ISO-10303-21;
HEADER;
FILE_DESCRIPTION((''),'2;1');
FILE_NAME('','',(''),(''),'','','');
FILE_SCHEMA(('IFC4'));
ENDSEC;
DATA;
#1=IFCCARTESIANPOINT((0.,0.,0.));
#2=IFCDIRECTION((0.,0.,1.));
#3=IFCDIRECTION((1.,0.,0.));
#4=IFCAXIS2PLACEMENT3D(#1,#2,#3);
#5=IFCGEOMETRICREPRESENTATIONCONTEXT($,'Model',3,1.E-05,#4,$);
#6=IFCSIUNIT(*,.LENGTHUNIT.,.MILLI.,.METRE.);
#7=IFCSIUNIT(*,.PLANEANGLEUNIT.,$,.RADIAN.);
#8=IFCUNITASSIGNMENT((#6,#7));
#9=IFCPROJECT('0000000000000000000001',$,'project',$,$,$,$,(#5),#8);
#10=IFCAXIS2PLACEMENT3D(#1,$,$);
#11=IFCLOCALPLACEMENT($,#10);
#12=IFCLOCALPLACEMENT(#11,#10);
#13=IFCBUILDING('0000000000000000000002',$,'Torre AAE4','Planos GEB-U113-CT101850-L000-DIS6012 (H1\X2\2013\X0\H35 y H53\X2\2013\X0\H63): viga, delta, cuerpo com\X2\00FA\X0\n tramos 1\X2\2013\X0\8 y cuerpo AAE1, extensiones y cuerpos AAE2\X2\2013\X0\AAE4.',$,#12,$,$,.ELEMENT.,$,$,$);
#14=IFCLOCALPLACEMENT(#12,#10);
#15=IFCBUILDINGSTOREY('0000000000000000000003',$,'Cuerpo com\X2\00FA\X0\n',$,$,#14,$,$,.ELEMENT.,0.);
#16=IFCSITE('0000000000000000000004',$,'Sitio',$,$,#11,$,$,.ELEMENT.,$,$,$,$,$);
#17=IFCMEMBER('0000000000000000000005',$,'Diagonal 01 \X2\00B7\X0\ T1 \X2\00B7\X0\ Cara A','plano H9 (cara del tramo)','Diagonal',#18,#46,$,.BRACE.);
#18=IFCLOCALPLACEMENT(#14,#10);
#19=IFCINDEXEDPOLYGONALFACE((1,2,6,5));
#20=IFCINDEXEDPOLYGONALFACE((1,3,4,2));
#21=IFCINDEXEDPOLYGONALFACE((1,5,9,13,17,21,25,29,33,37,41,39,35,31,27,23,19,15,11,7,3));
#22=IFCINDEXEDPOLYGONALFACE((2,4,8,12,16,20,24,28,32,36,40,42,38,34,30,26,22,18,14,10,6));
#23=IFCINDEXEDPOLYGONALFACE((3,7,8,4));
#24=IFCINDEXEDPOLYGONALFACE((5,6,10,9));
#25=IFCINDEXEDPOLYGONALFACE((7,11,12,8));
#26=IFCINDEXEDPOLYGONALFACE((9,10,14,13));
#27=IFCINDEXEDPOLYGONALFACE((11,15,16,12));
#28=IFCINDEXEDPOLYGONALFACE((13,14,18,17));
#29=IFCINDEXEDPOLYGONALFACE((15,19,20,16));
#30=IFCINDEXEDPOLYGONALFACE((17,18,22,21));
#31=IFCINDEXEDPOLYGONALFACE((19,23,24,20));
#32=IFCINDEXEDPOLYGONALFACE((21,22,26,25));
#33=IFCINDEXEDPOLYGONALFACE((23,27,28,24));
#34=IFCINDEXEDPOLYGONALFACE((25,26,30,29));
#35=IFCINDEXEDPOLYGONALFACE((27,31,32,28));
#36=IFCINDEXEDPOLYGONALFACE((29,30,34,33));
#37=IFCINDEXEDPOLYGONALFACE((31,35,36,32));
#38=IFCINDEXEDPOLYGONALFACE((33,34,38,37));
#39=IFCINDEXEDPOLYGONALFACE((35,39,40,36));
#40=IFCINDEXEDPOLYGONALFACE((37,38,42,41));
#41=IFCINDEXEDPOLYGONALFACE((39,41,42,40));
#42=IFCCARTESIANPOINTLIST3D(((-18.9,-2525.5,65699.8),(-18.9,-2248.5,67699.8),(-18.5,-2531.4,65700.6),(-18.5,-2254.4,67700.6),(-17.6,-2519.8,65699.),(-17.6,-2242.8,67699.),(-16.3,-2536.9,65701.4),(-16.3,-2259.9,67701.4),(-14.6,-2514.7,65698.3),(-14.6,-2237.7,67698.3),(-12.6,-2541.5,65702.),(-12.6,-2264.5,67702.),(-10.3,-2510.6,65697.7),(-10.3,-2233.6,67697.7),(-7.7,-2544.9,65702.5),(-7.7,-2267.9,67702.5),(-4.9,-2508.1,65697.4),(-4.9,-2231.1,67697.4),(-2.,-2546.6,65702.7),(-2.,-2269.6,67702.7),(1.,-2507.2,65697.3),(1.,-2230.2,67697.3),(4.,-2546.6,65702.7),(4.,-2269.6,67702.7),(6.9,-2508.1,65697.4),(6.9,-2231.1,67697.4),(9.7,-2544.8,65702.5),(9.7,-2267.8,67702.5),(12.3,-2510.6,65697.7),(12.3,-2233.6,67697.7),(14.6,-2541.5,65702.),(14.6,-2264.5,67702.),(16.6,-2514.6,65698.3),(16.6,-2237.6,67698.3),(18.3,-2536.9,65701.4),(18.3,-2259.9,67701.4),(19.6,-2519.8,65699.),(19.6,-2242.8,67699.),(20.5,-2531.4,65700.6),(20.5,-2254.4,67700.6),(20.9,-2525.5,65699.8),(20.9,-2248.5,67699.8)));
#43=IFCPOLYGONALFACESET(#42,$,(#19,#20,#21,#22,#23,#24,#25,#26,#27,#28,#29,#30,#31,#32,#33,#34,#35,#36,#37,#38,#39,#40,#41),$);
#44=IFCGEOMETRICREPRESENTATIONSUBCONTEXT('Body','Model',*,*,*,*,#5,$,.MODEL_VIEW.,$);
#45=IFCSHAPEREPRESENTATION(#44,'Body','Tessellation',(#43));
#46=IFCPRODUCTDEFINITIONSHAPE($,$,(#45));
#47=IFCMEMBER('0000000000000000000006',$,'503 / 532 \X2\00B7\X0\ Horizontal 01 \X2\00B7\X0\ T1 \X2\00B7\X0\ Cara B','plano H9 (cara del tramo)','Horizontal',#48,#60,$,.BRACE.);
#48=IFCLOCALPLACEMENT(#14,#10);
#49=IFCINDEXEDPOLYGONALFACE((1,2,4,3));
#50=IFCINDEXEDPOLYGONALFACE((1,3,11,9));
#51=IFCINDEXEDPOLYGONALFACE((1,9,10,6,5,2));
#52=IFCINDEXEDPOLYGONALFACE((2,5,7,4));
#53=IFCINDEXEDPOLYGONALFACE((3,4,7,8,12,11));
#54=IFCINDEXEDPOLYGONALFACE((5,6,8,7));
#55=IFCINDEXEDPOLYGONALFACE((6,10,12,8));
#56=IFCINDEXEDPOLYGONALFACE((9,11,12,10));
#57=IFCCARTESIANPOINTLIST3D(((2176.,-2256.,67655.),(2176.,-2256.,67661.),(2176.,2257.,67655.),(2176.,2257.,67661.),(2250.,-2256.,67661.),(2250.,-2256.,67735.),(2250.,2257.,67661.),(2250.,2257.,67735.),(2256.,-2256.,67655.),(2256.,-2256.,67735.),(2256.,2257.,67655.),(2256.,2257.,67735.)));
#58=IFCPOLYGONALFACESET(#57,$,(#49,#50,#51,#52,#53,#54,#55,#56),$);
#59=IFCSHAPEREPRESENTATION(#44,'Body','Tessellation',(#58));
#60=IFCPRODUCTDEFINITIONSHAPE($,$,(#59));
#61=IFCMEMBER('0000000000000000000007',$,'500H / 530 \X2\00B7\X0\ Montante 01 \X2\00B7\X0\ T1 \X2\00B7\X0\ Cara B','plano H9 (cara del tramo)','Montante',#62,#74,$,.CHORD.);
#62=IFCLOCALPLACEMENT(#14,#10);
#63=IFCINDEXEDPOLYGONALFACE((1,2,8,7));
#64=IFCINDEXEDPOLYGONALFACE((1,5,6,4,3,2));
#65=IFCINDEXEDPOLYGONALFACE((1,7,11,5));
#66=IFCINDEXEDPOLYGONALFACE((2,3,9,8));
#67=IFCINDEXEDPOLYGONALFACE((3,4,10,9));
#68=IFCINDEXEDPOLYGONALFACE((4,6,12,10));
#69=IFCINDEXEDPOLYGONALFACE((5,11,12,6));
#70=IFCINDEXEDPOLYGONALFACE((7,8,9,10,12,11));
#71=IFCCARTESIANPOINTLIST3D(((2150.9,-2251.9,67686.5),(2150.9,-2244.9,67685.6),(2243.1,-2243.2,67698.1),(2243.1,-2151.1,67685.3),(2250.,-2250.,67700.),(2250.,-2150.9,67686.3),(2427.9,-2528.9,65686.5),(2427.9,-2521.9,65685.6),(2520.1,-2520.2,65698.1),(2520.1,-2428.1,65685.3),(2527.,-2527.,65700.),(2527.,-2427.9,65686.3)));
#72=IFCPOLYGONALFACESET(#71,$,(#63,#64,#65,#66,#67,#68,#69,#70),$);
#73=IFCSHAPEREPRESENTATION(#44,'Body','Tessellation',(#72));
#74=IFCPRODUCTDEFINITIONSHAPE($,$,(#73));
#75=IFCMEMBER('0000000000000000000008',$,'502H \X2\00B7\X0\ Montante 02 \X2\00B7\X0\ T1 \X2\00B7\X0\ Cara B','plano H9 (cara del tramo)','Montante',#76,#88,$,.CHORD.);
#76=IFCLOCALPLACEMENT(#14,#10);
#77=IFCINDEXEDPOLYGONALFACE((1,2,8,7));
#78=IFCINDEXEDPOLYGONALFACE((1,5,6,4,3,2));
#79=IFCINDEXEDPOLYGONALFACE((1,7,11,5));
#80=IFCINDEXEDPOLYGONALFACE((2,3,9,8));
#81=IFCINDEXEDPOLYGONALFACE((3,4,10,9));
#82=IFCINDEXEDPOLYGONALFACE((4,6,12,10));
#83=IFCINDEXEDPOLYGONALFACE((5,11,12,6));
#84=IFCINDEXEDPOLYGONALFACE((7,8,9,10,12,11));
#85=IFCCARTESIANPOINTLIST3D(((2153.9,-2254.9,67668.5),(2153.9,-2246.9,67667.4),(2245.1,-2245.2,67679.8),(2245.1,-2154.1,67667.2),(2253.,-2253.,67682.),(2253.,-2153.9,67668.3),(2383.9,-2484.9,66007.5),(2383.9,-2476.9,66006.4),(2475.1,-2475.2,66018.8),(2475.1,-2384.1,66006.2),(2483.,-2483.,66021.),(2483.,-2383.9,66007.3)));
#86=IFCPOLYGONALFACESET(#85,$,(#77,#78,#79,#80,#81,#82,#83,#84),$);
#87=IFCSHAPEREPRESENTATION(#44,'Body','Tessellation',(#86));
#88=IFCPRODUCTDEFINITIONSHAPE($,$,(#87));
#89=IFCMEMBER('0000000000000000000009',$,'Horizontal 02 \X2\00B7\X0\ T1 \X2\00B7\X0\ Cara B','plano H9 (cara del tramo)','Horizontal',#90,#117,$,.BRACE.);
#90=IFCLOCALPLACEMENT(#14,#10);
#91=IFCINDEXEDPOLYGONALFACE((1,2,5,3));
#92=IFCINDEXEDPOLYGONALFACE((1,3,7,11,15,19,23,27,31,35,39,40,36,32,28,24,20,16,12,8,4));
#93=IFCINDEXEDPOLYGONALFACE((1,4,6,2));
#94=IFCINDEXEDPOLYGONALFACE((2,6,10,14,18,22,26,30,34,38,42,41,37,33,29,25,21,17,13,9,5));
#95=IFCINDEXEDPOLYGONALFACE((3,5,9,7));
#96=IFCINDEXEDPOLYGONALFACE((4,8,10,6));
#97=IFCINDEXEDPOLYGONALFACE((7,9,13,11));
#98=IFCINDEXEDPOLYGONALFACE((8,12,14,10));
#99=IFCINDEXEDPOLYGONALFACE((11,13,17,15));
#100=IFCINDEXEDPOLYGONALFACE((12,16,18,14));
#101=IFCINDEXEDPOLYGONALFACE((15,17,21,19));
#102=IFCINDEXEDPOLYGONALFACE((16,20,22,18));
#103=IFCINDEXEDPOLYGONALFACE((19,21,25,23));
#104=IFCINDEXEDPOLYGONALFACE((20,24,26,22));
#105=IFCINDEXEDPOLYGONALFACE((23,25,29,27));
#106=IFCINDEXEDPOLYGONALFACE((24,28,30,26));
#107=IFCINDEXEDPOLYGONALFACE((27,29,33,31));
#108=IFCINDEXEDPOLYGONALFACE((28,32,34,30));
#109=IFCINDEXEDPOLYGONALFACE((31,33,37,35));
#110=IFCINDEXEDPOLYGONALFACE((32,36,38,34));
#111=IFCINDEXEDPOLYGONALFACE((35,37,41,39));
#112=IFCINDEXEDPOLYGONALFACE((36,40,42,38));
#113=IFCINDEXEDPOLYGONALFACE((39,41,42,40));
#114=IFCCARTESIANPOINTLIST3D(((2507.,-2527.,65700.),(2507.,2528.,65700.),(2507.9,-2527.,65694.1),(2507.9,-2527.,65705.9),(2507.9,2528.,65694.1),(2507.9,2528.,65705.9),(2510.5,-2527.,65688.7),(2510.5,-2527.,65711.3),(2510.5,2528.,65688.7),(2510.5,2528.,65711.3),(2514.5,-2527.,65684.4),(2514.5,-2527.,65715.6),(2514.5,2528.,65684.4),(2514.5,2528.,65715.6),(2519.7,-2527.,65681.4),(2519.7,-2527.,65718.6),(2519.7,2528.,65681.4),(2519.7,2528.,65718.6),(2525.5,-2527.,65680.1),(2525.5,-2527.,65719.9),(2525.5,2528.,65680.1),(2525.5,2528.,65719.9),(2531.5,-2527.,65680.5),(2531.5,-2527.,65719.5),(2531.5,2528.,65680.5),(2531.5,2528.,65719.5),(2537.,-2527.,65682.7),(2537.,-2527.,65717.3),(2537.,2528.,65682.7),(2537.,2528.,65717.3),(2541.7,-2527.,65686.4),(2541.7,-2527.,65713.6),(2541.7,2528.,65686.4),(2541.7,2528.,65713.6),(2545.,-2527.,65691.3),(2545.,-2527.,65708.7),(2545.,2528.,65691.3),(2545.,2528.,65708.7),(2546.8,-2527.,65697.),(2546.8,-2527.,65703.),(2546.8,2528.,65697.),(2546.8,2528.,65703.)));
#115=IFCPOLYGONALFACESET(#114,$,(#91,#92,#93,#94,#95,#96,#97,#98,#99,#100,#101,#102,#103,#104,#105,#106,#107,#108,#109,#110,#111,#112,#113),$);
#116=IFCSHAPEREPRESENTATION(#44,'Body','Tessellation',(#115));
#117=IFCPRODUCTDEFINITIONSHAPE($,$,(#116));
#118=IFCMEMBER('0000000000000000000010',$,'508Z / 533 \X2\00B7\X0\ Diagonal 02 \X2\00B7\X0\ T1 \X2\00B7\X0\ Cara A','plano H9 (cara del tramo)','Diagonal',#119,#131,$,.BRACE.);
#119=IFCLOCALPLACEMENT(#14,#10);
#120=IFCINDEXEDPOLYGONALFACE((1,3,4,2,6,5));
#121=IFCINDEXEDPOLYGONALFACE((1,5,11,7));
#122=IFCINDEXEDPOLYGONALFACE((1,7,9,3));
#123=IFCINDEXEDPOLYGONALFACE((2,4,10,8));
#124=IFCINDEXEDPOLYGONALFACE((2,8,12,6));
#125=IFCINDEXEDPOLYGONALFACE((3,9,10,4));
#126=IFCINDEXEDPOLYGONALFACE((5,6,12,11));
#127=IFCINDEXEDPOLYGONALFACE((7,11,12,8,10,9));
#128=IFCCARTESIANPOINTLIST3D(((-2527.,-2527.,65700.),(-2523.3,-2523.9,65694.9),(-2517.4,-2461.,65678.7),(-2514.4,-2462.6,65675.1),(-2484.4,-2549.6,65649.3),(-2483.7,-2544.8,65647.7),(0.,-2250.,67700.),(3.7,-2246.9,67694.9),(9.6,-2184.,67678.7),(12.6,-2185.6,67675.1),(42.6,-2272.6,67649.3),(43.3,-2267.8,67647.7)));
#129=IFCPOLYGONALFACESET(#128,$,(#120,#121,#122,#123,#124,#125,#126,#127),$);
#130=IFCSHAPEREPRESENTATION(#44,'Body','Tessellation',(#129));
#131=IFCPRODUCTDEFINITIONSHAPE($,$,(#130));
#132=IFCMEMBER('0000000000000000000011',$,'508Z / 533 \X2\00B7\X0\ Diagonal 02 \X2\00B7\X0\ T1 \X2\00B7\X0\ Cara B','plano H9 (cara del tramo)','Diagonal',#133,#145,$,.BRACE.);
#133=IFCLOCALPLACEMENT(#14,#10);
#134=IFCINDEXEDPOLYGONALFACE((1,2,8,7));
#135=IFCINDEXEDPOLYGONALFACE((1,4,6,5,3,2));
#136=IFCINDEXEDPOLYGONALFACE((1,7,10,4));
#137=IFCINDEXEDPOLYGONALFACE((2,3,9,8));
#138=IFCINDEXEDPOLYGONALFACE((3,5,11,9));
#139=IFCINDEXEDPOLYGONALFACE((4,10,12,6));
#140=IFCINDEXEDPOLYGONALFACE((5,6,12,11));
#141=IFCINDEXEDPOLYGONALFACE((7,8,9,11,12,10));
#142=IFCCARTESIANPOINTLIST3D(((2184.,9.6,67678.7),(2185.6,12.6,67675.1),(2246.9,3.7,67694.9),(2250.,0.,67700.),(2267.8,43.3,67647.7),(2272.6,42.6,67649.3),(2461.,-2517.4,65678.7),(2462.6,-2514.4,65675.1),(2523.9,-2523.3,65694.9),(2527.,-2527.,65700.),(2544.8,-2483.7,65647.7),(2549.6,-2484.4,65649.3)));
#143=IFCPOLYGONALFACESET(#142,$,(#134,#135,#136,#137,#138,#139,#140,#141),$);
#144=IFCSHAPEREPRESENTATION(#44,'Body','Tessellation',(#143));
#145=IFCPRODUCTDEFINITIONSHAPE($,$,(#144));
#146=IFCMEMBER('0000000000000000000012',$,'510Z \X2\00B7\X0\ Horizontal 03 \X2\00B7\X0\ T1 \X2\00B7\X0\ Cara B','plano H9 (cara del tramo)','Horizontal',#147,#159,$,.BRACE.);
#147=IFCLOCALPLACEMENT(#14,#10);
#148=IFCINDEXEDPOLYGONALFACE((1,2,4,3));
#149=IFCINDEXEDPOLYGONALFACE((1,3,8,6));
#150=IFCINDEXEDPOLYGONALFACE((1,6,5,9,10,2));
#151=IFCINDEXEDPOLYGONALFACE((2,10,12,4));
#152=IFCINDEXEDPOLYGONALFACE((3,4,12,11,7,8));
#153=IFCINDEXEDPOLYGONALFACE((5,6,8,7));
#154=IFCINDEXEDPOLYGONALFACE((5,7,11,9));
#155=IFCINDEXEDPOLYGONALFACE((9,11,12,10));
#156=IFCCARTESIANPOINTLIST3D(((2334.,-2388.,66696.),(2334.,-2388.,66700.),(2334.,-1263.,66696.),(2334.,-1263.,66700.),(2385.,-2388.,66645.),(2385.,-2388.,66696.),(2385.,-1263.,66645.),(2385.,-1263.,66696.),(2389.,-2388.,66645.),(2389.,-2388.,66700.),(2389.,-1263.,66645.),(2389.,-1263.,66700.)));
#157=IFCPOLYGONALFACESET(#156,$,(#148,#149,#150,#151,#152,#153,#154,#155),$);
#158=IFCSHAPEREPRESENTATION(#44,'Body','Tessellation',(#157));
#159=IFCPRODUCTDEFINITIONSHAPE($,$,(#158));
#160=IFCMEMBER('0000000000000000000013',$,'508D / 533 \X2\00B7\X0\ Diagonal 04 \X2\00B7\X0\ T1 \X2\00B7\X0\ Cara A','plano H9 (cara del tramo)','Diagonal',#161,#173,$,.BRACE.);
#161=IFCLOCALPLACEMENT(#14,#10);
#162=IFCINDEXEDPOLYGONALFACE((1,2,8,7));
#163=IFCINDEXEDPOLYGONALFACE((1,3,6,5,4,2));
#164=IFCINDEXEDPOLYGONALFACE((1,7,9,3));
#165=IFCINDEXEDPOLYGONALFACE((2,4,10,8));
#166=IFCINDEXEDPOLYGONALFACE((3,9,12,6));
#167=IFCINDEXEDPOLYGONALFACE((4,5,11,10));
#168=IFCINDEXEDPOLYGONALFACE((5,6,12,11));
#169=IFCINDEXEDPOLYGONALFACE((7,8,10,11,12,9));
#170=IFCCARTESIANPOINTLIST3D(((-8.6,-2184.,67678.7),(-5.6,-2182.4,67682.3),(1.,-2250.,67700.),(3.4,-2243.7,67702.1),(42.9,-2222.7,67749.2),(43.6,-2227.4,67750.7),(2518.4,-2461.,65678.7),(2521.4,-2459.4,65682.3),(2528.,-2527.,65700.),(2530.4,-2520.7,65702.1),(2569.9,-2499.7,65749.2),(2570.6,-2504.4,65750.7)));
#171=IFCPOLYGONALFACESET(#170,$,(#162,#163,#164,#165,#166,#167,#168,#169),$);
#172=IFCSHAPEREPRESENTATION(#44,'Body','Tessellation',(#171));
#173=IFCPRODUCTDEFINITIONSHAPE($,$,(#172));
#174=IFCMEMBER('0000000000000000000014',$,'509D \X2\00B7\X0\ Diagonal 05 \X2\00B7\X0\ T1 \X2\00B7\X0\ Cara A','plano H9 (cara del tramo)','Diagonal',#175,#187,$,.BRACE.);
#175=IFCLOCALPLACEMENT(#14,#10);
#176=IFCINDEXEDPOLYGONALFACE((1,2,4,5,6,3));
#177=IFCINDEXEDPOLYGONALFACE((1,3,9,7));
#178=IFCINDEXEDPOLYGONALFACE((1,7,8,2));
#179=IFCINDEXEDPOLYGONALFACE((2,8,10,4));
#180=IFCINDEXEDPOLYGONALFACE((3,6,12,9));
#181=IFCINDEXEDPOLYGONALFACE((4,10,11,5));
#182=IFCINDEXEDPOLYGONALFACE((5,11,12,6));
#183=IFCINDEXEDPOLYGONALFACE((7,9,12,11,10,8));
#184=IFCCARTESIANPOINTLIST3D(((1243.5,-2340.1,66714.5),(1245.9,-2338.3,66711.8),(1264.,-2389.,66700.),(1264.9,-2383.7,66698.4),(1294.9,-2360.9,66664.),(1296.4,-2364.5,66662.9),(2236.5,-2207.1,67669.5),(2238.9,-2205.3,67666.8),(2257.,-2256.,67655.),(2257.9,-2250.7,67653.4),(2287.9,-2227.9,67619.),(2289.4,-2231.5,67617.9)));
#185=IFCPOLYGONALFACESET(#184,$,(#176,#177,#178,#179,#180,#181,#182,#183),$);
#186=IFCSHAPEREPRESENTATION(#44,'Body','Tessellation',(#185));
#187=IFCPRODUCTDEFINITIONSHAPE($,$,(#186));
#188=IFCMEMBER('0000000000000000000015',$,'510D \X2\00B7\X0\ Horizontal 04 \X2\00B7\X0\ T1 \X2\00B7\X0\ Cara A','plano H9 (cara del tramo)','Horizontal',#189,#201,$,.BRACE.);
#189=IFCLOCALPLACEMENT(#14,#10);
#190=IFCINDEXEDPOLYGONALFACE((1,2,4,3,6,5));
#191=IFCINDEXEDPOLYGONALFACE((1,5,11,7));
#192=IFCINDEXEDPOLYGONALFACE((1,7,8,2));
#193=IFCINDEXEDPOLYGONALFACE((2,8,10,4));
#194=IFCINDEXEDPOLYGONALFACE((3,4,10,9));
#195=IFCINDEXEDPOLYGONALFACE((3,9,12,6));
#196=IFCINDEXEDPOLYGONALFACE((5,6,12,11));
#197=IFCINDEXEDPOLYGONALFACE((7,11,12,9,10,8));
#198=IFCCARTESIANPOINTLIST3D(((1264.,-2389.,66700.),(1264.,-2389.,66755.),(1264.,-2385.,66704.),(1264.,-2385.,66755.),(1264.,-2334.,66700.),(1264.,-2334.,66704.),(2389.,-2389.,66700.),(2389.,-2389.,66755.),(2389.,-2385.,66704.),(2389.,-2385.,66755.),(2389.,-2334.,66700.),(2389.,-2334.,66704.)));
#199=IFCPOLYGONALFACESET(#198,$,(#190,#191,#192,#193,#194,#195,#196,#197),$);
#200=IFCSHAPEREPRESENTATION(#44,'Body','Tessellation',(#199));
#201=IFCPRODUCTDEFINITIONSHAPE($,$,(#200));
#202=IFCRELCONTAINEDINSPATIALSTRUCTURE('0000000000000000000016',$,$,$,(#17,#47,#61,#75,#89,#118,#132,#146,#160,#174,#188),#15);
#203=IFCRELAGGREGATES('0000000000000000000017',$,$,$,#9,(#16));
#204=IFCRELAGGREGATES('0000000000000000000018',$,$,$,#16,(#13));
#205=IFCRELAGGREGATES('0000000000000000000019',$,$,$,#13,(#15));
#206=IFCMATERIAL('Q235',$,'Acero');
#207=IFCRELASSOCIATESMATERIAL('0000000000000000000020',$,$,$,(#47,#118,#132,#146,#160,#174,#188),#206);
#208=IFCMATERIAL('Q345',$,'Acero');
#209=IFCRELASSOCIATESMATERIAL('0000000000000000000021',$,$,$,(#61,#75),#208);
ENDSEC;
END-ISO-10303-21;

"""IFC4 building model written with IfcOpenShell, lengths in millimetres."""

from ifc_helpers import new_model, si_unit, frame, frame_2d, origin, origin_with_axes, place, context, subcontext, project, spatial, circle, l_section, extrude, material, element, save


model = new_model("IFC4")

# Units and contexts
model_context = context("Model", 3, precision=1e-05, world=origin_with_axes())
body_context = subcontext(model_context, "Body", "Model", "MODEL_VIEW")
ifc_project = project(units=[si_unit("LENGTHUNIT", "METRE", prefix="MILLI"), si_unit("PLANEANGLEUNIT", "RADIAN")], contexts=[model_context])

# Site, building, storey
site_placement = place(None, origin())
site = spatial("IfcSite", under=ifc_project, at=site_placement, Name="Sitio", CompositionType="ELEMENT")
building_placement = place(site_placement, origin())
building = spatial("IfcBuilding", under=site, at=building_placement, Name="Torre AAE4", Description="Planos GEB-U113-CT101850-L000-DIS6012 (H1–H35 y H53–H63): viga, delta, cuerpo común tramos 1–8 y cuerpo AAE1, extensiones y cuerpos AAE2–AAE4.", CompositionType="ELEMENT")
storey_placement = place(building_placement, origin())
storey = spatial("IfcBuildingStorey", under=building, at=storey_placement, Name="Cuerpo común", CompositionType="ELEMENT", Elevation=0.0)

# Members
member_1_placement = place(storey_placement, frame((1.0, -2527.0, 65700.0), z_axis=(0.0, 0.13719, 0.990545), x_axis=(-0.000423, 0.990545, -0.13719)))
element("IfcMember", 1, at=member_1_placement, inside=storey, Name="Diagonal 01 · T1 · Cara A", Description="plano H9 (cara del tramo)", ObjectType="Diagonal", PredefinedType="BRACE", context=body_context, shape_type="SweptSolid", body=[
    extrude(circle(Radius=20.0), None, (0.0, 0.0, 1.0), 2019.1),
])
ifc_material_1 = material(Name="Q235", Category="Acero")
member_2_placement = place(storey_placement, frame((2256.0, -2256.0, 67655.0), z_axis=(0.0, 1.0, 0.0), x_axis=(-1.0, 0.0, 0.0)))
element("IfcMember", 2, at=member_2_placement, inside=storey, material=ifc_material_1, Name="503 / 532 · Horizontal 01 · T1 · Cara B", Description="plano H9 (cara del tramo)", ObjectType="Horizontal", PredefinedType="BRACE", context=body_context, shape_type="SweptSolid", body=[
    extrude(l_section(Depth=80.0, Width=80.0, Thickness=6.0, at=frame_2d((40.0, 40.0))), None, (0.0, 0.0, 1.0), 4513.0),
])
ifc_material_2 = material(Name="Q345", Category="Acero")
member_3_placement = place(storey_placement, frame((2250.0, -2250.0, 67700.0), z_axis=(0.135917, -0.135917, -0.981353), x_axis=(-0.99072, -0.018647, -0.134632)))
element("IfcMember", 3, at=member_3_placement, inside=storey, material=ifc_material_2, Name="500H / 530 · Montante 01 · T1 · Cara B", Description="plano H9 (cara del tramo)", ObjectType="Montante", PredefinedType="CHORD", context=body_context, shape_type="SweptSolid", body=[
    extrude(l_section(Depth=100.0, Width=100.0, Thickness=7.0, at=frame_2d((50.0, 50.0))), None, (0.0, 0.0, 1.0), 2038.0),
])
member_4_placement = place(storey_placement, frame((2253.0, -2253.0, 67682.0), z_axis=(0.13589, -0.13589, -0.98136), x_axis=(-0.990724, -0.018639, -0.134605)))
element("IfcMember", 4, at=member_4_placement, inside=storey, material=ifc_material_2, Name="502H · Montante 02 · T1 · Cara B", Description="plano H9 (cara del tramo)", ObjectType="Montante", PredefinedType="CHORD", context=body_context, shape_type="SweptSolid", body=[
    extrude(l_section(Depth=100.0, Width=100.0, Thickness=8.0, at=frame_2d((50.0, 50.0))), None, (0.0, 0.0, 1.0), 1692.5),
])
member_5_placement = place(storey_placement, frame((2527.0, -2527.0, 65700.0), z_axis=(0.0, 1.0, 0.0), x_axis=(-1.0, 0.0, 0.0)))
element("IfcMember", 5, at=member_5_placement, inside=storey, Name="Horizontal 02 · T1 · Cara B", Description="plano H9 (cara del tramo)", ObjectType="Horizontal", PredefinedType="BRACE", context=body_context, shape_type="SweptSolid", body=[
    extrude(circle(Radius=20.0), None, (0.0, 0.0, 1.0), 5055.0),
])
for number, where, z_axis, x_axis, name in (
    (6, (0.0, -2250.0, 67700.0), (-0.781247, -0.085637, -0.61832), (0.137116, 0.942809, -0.303825), "508Z / 533 · Diagonal 02 · T1 · Cara A"),
    (7, (2250.0, 0.0, 67700.0), (0.085637, -0.781247, -0.61832), (-0.942809, 0.137116, -0.303825), "508Z / 533 · Diagonal 02 · T1 · Cara B"),
):
    element("IfcMember", number, at=place(storey_placement, frame(where, z_axis=z_axis, x_axis=x_axis)), inside=storey, material=ifc_material_1, Name=name, Description="plano H9 (cara del tramo)", ObjectType="Diagonal", PredefinedType="BRACE", context=body_context, shape_type="SweptSolid", body=[
        extrude(l_section(Depth=70.0, Width=70.0, Thickness=5.0, at=frame_2d((35.0, 35.0))), None, (0.0, 0.0, 1.0), 3234.6),
    ])
member_6_placement = place(storey_placement, frame((2389.0, -1263.0, 66700.0), z_axis=(0.0, -1.0, 0.0), x_axis=(-1.0, 0.0, 0.0)))
element("IfcMember", 8, at=member_6_placement, inside=storey, material=ifc_material_1, Name="510Z · Horizontal 03 · T1 · Cara B", Description="plano H9 (cara del tramo)", ObjectType="Horizontal", PredefinedType="BRACE", context=body_context, shape_type="SweptSolid", body=[
    extrude(l_section(Depth=55.0, Width=55.0, Thickness=4.0, at=frame_2d((27.5, 27.5))), None, (0.0, 0.0, 1.0), 1125.0),
])
member_7_placement = place(storey_placement, frame((1.0, -2250.0, 67700.0), z_axis=(0.781247, -0.085637, -0.61832), x_axis=(-0.137269, 0.942728, -0.304007)))
element("IfcMember", 9, at=member_7_placement, inside=storey, material=ifc_material_1, Name="508D / 533 · Diagonal 04 · T1 · Cara A", Description="plano H9 (cara del tramo)", ObjectType="Diagonal", PredefinedType="BRACE", context=body_context, shape_type="SweptSolid", body=[
    extrude(l_section(Depth=70.0, Width=70.0, Thickness=5.0, at=frame_2d((35.0, 35.0))), None, (0.0, 0.0, 1.0), 3234.6),
])
member_8_placement = place(storey_placement, frame((2257.0, -2256.0, 67655.0), z_axis=(-0.717428, -0.096091, -0.689974), x_axis=(-0.372625, 0.889775, 0.263535)))
element("IfcMember", 10, at=member_8_placement, inside=storey, material=ifc_material_1, Name="509D · Diagonal 05 · T1 · Cara A", Description="plano H9 (cara del tramo)", ObjectType="Diagonal", PredefinedType="BRACE", context=body_context, shape_type="SweptSolid", body=[
    extrude(l_section(Depth=55.0, Width=55.0, Thickness=4.0, at=frame_2d((27.5, 27.5))), None, (0.0, 0.0, 1.0), 1384.1),
])
member_9_placement = place(storey_placement, frame((1264.0, -2389.0, 66700.0), z_axis=(1.0, 0.0, 0.0), x_axis=(0.0, 1.0, 0.0)))
element("IfcMember", 11, at=member_9_placement, inside=storey, material=ifc_material_1, Name="510D · Horizontal 04 · T1 · Cara A", Description="plano H9 (cara del tramo)", ObjectType="Horizontal", PredefinedType="BRACE", context=body_context, shape_type="SweptSolid", body=[
    extrude(l_section(Depth=55.0, Width=55.0, Thickness=4.0, at=frame_2d((27.5, 27.5))), None, (0.0, 0.0, 1.0), 1125.0),
])

save(model, "model.ifc")
